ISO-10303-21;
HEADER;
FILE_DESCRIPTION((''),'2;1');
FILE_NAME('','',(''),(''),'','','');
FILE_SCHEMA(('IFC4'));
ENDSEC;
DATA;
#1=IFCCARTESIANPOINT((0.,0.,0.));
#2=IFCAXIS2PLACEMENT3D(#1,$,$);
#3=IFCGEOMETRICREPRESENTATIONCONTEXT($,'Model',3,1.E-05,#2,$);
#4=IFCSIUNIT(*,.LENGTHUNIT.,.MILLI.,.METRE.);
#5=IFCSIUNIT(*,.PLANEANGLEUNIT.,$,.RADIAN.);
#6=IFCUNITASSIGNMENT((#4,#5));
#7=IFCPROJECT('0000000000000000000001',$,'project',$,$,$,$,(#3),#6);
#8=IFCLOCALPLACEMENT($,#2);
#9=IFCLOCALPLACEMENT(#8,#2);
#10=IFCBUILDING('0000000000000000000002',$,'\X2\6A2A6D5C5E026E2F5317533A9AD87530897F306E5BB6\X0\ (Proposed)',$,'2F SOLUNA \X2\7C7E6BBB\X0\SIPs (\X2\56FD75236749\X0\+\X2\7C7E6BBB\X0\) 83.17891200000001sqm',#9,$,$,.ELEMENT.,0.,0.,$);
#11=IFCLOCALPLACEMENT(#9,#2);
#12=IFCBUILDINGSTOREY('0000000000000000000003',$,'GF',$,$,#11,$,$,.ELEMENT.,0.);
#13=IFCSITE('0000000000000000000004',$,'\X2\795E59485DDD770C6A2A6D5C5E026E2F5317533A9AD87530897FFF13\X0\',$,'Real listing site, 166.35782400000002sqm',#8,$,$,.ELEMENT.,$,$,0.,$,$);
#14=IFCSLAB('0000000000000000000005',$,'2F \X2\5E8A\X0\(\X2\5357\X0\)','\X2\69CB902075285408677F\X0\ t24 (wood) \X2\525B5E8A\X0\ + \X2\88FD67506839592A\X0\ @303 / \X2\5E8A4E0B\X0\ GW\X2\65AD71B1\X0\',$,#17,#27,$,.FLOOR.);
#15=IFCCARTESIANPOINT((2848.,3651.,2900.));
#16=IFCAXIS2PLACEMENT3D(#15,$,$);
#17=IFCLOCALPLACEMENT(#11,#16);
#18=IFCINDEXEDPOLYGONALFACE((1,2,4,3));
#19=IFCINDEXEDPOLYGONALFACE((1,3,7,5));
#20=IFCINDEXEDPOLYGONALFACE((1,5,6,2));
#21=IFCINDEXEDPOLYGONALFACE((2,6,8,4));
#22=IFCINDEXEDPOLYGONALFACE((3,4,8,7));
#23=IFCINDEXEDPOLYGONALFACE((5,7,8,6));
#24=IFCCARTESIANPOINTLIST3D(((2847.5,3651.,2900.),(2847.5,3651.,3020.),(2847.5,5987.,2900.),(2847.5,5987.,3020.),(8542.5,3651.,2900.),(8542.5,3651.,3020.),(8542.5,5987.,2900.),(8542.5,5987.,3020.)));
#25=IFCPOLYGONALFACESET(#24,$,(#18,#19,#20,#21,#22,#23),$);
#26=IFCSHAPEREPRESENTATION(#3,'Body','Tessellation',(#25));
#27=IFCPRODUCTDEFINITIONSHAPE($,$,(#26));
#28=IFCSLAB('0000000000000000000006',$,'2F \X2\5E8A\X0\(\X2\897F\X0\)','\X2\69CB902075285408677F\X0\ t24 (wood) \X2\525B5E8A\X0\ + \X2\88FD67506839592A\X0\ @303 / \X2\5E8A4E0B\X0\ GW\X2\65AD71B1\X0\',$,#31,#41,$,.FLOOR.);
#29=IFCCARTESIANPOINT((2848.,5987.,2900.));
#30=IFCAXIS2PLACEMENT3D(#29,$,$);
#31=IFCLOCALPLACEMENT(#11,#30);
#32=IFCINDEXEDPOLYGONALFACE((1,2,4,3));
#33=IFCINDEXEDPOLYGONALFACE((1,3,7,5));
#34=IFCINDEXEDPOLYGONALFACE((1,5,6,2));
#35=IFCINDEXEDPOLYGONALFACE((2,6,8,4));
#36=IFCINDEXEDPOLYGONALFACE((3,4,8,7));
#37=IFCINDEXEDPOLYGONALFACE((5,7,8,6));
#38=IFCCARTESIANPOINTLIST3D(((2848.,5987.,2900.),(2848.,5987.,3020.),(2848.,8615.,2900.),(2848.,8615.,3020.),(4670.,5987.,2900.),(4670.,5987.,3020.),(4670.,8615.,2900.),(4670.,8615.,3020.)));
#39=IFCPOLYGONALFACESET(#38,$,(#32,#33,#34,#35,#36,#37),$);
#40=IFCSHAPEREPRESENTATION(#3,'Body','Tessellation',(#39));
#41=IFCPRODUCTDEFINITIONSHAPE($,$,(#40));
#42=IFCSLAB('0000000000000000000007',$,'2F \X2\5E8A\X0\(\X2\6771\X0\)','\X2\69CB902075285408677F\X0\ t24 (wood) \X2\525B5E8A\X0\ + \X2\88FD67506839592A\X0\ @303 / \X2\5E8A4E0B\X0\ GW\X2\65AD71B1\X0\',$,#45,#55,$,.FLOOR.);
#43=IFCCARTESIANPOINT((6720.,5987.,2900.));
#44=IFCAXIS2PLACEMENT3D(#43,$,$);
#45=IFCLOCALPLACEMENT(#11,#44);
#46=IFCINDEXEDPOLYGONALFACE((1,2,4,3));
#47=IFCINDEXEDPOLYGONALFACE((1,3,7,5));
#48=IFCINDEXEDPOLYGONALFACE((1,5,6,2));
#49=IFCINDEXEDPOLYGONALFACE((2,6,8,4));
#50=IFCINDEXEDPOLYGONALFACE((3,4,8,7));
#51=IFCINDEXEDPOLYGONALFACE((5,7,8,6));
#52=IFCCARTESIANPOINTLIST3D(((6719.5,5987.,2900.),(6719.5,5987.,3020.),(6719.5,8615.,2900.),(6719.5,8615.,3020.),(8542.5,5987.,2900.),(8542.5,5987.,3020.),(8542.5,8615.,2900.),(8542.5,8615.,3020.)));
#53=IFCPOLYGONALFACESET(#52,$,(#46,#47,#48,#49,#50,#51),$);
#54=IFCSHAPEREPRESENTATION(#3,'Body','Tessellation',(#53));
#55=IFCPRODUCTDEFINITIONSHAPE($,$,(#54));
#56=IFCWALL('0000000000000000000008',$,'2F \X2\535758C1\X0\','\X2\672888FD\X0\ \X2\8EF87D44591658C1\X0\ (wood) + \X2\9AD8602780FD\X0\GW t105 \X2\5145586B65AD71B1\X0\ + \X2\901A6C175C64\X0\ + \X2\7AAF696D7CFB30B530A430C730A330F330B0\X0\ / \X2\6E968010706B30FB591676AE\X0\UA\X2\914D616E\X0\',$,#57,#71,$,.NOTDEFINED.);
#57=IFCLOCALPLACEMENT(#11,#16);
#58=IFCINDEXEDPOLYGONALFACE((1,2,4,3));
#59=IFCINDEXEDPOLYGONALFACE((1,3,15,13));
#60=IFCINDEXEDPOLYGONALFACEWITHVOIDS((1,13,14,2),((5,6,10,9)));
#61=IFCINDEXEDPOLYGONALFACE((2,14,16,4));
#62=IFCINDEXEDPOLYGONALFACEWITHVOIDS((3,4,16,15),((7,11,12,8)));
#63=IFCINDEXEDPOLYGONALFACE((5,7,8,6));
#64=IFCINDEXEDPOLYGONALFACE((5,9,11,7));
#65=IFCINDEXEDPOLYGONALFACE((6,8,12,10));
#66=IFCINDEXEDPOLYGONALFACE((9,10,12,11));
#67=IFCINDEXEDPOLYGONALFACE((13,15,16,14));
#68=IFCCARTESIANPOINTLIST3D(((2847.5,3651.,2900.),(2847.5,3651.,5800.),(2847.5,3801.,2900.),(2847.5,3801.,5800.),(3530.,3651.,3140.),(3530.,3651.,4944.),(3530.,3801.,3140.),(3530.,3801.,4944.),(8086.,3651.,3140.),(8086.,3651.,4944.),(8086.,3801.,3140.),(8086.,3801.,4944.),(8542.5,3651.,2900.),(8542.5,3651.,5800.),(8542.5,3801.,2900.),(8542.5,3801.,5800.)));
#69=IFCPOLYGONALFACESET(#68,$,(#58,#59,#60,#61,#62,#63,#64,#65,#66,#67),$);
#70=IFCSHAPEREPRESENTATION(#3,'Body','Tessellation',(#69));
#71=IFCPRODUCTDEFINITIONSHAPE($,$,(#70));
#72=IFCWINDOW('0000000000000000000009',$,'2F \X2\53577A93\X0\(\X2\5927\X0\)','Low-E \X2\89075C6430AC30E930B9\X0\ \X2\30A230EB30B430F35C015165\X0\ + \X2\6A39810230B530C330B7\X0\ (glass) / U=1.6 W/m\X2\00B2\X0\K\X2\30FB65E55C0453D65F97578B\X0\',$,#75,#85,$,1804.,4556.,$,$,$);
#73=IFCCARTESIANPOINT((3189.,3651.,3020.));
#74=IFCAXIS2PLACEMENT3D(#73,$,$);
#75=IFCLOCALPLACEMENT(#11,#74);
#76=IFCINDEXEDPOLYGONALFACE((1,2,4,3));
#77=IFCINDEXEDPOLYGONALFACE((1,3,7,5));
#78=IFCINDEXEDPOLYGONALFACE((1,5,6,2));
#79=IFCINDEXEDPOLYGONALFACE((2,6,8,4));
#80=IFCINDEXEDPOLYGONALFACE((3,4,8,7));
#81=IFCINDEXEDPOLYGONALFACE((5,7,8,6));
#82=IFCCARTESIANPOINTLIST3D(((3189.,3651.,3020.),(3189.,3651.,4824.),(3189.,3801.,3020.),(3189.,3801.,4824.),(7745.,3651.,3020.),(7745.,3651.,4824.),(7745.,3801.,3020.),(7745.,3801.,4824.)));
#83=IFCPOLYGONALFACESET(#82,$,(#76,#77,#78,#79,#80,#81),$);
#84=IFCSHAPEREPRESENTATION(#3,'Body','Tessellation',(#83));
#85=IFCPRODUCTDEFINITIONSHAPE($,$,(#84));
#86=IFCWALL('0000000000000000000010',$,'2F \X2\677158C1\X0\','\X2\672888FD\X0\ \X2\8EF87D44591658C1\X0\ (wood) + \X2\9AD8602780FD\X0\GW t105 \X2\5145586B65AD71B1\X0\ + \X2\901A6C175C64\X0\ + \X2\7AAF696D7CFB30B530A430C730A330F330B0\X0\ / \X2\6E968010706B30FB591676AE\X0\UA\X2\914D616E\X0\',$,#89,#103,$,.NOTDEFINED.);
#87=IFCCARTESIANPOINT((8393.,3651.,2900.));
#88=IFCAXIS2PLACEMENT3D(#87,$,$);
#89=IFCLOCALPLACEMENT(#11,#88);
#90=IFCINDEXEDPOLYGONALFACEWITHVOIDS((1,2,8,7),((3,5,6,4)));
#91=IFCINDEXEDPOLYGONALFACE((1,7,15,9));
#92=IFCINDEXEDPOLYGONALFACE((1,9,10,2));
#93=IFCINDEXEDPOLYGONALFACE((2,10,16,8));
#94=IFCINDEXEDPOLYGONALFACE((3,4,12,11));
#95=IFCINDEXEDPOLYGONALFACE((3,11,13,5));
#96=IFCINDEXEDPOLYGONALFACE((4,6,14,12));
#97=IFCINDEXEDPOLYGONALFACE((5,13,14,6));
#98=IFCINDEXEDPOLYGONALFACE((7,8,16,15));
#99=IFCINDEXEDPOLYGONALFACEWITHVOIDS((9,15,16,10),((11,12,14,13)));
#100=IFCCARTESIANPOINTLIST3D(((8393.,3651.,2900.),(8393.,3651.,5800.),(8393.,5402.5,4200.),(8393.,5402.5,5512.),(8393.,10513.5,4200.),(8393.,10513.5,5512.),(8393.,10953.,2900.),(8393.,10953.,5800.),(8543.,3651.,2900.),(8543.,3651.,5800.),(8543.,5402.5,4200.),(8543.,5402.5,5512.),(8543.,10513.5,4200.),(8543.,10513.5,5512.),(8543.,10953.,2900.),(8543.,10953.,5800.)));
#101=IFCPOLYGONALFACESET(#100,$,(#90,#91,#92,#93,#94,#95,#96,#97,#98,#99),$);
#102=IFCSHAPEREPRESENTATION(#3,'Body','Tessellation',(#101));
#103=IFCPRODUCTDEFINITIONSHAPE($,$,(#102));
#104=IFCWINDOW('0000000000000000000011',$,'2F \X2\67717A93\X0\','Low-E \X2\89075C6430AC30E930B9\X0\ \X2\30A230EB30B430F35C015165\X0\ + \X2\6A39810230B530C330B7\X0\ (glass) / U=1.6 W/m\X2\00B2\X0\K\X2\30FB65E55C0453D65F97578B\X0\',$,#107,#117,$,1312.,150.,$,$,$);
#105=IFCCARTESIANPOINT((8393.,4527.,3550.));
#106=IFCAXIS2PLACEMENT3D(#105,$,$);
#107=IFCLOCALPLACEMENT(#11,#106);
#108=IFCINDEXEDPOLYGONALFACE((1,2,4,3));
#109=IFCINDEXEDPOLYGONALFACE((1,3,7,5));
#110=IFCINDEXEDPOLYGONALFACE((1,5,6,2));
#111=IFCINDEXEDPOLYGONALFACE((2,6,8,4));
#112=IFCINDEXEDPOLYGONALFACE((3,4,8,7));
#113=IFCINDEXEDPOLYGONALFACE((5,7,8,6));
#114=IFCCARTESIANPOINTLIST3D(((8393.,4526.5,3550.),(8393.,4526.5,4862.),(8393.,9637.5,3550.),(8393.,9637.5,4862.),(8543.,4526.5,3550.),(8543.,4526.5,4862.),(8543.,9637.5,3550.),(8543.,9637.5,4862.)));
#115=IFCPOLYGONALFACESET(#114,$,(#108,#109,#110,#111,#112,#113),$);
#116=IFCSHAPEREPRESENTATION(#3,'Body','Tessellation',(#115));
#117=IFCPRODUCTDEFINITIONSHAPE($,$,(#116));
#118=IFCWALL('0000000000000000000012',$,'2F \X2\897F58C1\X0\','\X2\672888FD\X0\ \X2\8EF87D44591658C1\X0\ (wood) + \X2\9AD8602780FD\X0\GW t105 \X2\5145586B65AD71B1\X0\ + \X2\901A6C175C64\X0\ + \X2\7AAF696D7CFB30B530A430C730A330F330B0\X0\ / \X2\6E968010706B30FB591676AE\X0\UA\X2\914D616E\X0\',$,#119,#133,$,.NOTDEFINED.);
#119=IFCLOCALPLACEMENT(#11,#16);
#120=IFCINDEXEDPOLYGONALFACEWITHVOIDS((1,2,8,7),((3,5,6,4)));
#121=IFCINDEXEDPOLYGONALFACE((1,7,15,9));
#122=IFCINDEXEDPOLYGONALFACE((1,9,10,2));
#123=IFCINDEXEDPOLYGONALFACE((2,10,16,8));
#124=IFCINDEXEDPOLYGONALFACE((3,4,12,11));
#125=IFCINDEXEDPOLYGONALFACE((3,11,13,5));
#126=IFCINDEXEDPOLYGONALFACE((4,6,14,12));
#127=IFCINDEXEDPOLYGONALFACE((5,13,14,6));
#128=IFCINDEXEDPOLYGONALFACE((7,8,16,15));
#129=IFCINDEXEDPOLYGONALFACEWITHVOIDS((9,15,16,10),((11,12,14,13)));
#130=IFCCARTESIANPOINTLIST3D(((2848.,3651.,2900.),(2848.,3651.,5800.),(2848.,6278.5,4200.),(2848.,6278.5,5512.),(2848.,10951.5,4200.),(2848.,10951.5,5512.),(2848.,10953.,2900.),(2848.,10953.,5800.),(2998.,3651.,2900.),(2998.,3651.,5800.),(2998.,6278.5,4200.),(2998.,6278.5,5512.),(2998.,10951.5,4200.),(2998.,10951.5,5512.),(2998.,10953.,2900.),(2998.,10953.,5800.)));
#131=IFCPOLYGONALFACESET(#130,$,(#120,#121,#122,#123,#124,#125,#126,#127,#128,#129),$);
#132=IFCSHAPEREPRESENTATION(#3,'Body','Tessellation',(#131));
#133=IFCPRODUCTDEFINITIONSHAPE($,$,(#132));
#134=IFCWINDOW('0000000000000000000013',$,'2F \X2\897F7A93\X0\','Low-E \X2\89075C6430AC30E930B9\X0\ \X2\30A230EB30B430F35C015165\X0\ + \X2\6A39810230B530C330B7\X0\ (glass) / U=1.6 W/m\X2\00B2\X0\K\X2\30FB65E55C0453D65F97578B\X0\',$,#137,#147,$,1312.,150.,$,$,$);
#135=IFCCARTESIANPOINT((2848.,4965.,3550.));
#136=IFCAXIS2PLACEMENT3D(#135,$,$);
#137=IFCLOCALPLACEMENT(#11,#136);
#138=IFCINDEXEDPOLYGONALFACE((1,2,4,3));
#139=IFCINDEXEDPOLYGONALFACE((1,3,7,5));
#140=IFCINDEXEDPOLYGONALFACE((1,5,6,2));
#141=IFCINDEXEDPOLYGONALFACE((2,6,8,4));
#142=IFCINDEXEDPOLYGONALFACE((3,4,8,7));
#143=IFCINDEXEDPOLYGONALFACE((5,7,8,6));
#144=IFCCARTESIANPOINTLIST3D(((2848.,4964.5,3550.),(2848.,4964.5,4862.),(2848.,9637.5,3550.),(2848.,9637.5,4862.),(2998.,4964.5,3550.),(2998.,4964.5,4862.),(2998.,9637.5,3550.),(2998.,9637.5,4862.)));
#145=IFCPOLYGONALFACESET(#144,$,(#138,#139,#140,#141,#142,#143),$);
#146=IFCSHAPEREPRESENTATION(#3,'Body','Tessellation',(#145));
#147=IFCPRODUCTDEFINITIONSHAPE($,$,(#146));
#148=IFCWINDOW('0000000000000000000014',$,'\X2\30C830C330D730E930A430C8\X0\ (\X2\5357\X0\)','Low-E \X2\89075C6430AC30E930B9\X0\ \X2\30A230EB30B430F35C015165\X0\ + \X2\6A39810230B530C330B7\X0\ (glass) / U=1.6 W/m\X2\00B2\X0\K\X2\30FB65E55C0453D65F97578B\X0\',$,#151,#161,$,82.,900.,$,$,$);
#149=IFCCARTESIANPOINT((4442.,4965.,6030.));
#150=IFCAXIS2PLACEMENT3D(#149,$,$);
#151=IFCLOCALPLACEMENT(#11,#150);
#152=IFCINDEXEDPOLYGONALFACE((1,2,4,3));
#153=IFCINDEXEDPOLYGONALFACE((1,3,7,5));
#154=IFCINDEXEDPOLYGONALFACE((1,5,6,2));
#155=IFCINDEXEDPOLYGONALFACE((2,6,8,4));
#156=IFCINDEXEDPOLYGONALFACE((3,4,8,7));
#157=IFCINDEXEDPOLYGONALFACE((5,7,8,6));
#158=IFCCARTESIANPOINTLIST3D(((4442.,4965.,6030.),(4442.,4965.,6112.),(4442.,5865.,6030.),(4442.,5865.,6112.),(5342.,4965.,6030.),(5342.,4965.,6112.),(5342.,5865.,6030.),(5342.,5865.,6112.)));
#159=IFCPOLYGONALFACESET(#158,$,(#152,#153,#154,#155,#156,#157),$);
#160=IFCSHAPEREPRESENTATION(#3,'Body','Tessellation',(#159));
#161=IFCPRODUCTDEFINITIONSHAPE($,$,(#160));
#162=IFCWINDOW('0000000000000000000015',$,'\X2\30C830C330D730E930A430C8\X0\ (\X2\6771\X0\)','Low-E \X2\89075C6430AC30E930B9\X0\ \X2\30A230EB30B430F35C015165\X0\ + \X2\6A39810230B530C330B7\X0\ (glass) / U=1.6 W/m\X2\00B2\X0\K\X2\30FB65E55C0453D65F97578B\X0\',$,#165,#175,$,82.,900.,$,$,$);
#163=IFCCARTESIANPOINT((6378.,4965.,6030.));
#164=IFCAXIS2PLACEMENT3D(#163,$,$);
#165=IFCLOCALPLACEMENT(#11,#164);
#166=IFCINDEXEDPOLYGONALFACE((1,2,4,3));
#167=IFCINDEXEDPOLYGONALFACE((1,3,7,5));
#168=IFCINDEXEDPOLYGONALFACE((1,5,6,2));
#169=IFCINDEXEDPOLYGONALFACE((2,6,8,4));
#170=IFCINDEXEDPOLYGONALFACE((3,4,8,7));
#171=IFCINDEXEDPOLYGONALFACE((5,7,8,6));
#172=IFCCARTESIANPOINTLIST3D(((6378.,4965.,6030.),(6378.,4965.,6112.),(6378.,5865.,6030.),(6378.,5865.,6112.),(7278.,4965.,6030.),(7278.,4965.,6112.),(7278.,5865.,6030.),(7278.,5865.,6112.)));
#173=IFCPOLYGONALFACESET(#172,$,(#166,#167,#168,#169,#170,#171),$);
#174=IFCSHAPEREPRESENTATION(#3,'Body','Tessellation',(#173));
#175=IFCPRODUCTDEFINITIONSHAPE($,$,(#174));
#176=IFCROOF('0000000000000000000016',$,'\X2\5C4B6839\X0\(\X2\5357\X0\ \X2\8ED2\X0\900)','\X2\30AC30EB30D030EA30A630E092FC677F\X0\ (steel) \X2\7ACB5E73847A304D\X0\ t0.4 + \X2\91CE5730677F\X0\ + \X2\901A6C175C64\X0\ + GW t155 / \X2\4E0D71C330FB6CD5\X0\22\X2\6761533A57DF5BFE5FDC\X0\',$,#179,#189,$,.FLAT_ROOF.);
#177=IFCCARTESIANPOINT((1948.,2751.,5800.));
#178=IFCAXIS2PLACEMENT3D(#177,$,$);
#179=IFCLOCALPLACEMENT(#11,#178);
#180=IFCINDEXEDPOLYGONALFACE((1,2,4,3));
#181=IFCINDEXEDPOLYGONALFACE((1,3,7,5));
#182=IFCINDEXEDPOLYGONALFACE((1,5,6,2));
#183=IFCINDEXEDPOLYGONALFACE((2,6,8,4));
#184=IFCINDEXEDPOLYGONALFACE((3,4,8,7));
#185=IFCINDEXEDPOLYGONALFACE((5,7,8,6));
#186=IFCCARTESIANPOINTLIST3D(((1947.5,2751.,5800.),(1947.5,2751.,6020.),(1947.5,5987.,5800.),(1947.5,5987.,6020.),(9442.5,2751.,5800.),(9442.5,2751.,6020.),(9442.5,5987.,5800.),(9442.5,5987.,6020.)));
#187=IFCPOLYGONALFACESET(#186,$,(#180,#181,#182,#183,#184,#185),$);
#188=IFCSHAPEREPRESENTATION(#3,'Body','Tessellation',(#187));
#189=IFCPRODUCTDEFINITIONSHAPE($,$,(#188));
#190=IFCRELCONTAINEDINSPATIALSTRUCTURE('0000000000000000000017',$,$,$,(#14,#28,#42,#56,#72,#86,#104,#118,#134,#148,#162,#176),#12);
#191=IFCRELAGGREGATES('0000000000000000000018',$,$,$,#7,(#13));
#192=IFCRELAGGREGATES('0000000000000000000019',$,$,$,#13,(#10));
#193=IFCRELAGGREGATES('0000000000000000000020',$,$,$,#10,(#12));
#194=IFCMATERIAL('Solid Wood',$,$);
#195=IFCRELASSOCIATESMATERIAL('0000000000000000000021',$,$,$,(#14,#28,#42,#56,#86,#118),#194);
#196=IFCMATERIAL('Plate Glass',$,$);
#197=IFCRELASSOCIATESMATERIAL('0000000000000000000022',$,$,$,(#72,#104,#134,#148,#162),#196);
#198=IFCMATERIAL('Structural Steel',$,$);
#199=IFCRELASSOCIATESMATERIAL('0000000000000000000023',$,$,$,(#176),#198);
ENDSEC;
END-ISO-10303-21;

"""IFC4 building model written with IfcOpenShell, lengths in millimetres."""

from ifc_helpers import new_model, si_unit, frame, frame_2d, origin, place, context, project, spatial, rectangle, extrude, material, element, fill, save


model = new_model("IFC4")

# Units and contexts
model_context = context("Model", 3, precision=1e-05, world=origin())
ifc_project = project(units=[si_unit("LENGTHUNIT", "METRE", prefix="MILLI"), si_unit("PLANEANGLEUNIT", "RADIAN")], contexts=[model_context])

# Site, building, storey
site_placement = place(None, origin())
site = spatial("IfcSite", under=ifc_project, at=site_placement, Name="神奈川県横浜市港北区高田西３", ObjectType="Real listing site, 166.35782400000002sqm", CompositionType="ELEMENT", RefElevation=0.0)
building_placement = place(site_placement, origin())
building = spatial("IfcBuilding", under=site, at=building_placement, Name="横浜市港北区高田西の家 (Proposed)", ObjectType="2F SOLUNA 籾殻SIPs (国産杉+籾殻) 83.17891200000001sqm", CompositionType="ELEMENT", ElevationOfRefHeight=0.0, ElevationOfTerrain=0.0)
storey_placement = place(building_placement, origin())
storey = spatial("IfcBuildingStorey", under=building, at=storey_placement, Name="GF", CompositionType="ELEMENT", Elevation=0.0)

# Slabs
ifc_material_1 = material(Name="Solid Wood")
slab_1_placement = place(storey_placement, frame((2848.0, 3651.0, 2900.0)))
element("IfcSlab", 1, at=slab_1_placement, inside=storey, material=ifc_material_1, Name="2F 床(南)", Description="構造用合板 t24 (wood) 剛床 + 製材根太 @303 / 床下 GW断熱", PredefinedType="FLOOR", context=model_context, shape_type="SweptSolid", body=[
    extrude(rectangle(XDim=5695.0, YDim=2336.0, at=frame_2d((2847.0, 1168.0))), frame((2848.0, 3651.0, 2900.0)), (0.0, 0.0, 1.0), 120.0),
])
slab_2_placement = place(storey_placement, frame((2848.0, 5987.0, 2900.0)))
element("IfcSlab", 2, at=slab_2_placement, inside=storey, material=ifc_material_1, Name="2F 床(西)", Description="構造用合板 t24 (wood) 剛床 + 製材根太 @303 / 床下 GW断熱", PredefinedType="FLOOR", context=model_context, shape_type="SweptSolid", body=[
    extrude(rectangle(XDim=1822.0, YDim=2628.0, at=frame_2d((911.0, 1314.0))), frame((2848.0, 5987.0, 2900.0)), (0.0, 0.0, 1.0), 120.0),
])
slab_3_placement = place(storey_placement, frame((6720.0, 5987.0, 2900.0)))
element("IfcSlab", 3, at=slab_3_placement, inside=storey, material=ifc_material_1, Name="2F 床(東)", Description="構造用合板 t24 (wood) 剛床 + 製材根太 @303 / 床下 GW断熱", PredefinedType="FLOOR", context=model_context, shape_type="SweptSolid", body=[
    extrude(rectangle(XDim=1823.0, YDim=2628.0, at=frame_2d((911.0, 1314.0))), frame((6720.0, 5987.0, 2900.0)), (0.0, 0.0, 1.0), 120.0),
])

# Walls, openings, windows
wall_1_placement = place(storey_placement, frame((2848.0, 3651.0, 2900.0)))
wall_1 = element("IfcWall", 4, at=wall_1_placement, inside=storey, material=ifc_material_1, Name="2F 南壁", Description="木製 軸組外壁 (wood) + 高性能GW t105 充填断熱 + 通気層 + 窯業系サイディング / 準耐火・外皮UA配慮", PredefinedType="NOTDEFINED", context=model_context, shape_type="SweptSolid", body=[
    extrude(rectangle(XDim=5695.0, YDim=150.0, at=frame_2d((2847.0, 75.0))), frame((2848.0, 3651.0, 2900.0)), (0.0, 0.0, 1.0), 2900.0),
])
opening_1_placement = place(storey_placement, frame((3189.0, 3651.0, 3020.0)))
opening_1 = element("IfcOpeningElement", 5, at=opening_1_placement, cuts=wall_1, PredefinedType="NOTDEFINED", context=model_context, shape_type="SweptSolid", body=[
    extrude(rectangle(XDim=4556.0, YDim=150.0, at=frame_2d((2278.0, 75.0))), frame((3189.0, 3651.0, 3020.0)), (0.0, 0.0, 1.0), 1804.0),
])
ifc_material_2 = material(Name="Plate Glass")
window_1_placement = place(storey_placement, frame((3189.0, 3651.0, 3020.0)))
window_1 = element("IfcWindow", 6, at=window_1_placement, inside=storey, material=ifc_material_2, Name="2F 南窓(大)", Description="Low-E 複層ガラス アルゴン封入 + 樹脂サッシ (glass) / U=1.6 W/m²K・日射取得型", OverallHeight=1804.0, OverallWidth=4556.0, context=model_context, shape_type="SweptSolid", body=[
    extrude(rectangle(XDim=4556.0, YDim=150.0, at=frame_2d((2278.0, 75.0))), frame((3189.0, 3651.0, 3020.0)), (0.0, 0.0, 1.0), 1804.0),
])
fill(opening_1, window_1)
wall_2_placement = place(storey_placement, frame((8393.0, 3651.0, 2900.0)))
wall_2 = element("IfcWall", 7, at=wall_2_placement, inside=storey, material=ifc_material_1, Name="2F 東壁", Description="木製 軸組外壁 (wood) + 高性能GW t105 充填断熱 + 通気層 + 窯業系サイディング / 準耐火・外皮UA配慮", PredefinedType="NOTDEFINED", context=model_context, shape_type="SweptSolid", body=[
    extrude(rectangle(XDim=150.0, YDim=7302.0, at=frame_2d((75.0, 3651.0))), frame((8393.0, 3651.0, 2900.0)), (0.0, 0.0, 1.0), 2900.0),
])
opening_2_placement = place(storey_placement, frame((8393.0, 4527.0, 3550.0)))
opening_2 = element("IfcOpeningElement", 8, at=opening_2_placement, cuts=wall_2, PredefinedType="NOTDEFINED", context=model_context, shape_type="SweptSolid", body=[
    extrude(rectangle(XDim=150.0, YDim=5111.0, at=frame_2d((75.0, 2555.0))), frame((8393.0, 4527.0, 3550.0)), (0.0, 0.0, 1.0), 1312.0),
])
window_2_placement = place(storey_placement, frame((8393.0, 4527.0, 3550.0)))
window_2 = element("IfcWindow", 9, at=window_2_placement, inside=storey, material=ifc_material_2, Name="2F 東窓", Description="Low-E 複層ガラス アルゴン封入 + 樹脂サッシ (glass) / U=1.6 W/m²K・日射取得型", OverallHeight=1312.0, OverallWidth=150.0, context=model_context, shape_type="SweptSolid", body=[
    extrude(rectangle(XDim=150.0, YDim=5111.0, at=frame_2d((75.0, 2555.0))), frame((8393.0, 4527.0, 3550.0)), (0.0, 0.0, 1.0), 1312.0),
])
fill(opening_2, window_2)
wall_3_placement = place(storey_placement, frame((2848.0, 3651.0, 2900.0)))
wall_3 = element("IfcWall", 10, at=wall_3_placement, inside=storey, material=ifc_material_1, Name="2F 西壁", Description="木製 軸組外壁 (wood) + 高性能GW t105 充填断熱 + 通気層 + 窯業系サイディング / 準耐火・外皮UA配慮", PredefinedType="NOTDEFINED", context=model_context, shape_type="SweptSolid", body=[
    extrude(rectangle(XDim=150.0, YDim=7302.0, at=frame_2d((75.0, 3651.0))), frame((2848.0, 3651.0, 2900.0)), (0.0, 0.0, 1.0), 2900.0),
])
opening_3_placement = place(storey_placement, frame((2848.0, 4965.0, 3550.0)))
opening_3 = element("IfcOpeningElement", 11, at=opening_3_placement, cuts=wall_3, PredefinedType="NOTDEFINED", context=model_context, shape_type="SweptSolid", body=[
    extrude(rectangle(XDim=150.0, YDim=4673.0, at=frame_2d((75.0, 2336.0))), frame((2848.0, 4965.0, 3550.0)), (0.0, 0.0, 1.0), 1312.0),
])
window_3_placement = place(storey_placement, frame((2848.0, 4965.0, 3550.0)))
window_3 = element("IfcWindow", 12, at=window_3_placement, inside=storey, material=ifc_material_2, Name="2F 西窓", Description="Low-E 複層ガラス アルゴン封入 + 樹脂サッシ (glass) / U=1.6 W/m²K・日射取得型", OverallHeight=1312.0, OverallWidth=150.0, context=model_context, shape_type="SweptSolid", body=[
    extrude(rectangle(XDim=150.0, YDim=4673.0, at=frame_2d((75.0, 2336.0))), frame((2848.0, 4965.0, 3550.0)), (0.0, 0.0, 1.0), 1312.0),
])
fill(opening_3, window_3)

# Windows
window_4_placement = place(storey_placement, frame((4442.0, 4965.0, 6030.0)))
element("IfcWindow", 13, at=window_4_placement, inside=storey, material=ifc_material_2, Name="トップライト (南)", Description="Low-E 複層ガラス アルゴン封入 + 樹脂サッシ (glass) / U=1.6 W/m²K・日射取得型", OverallHeight=82.0, OverallWidth=900.0, context=model_context, shape_type="SweptSolid", body=[
    extrude(rectangle(XDim=900.0, YDim=900.0, at=frame_2d((450.0, 450.0))), frame((4442.0, 4965.0, 6030.0)), (0.0, 0.0, 1.0), 82.0),
])
window_5_placement = place(storey_placement, frame((6378.0, 4965.0, 6030.0)))
element("IfcWindow", 14, at=window_5_placement, inside=storey, material=ifc_material_2, Name="トップライト (東)", Description="Low-E 複層ガラス アルゴン封入 + 樹脂サッシ (glass) / U=1.6 W/m²K・日射取得型", OverallHeight=82.0, OverallWidth=900.0, context=model_context, shape_type="SweptSolid", body=[
    extrude(rectangle(XDim=900.0, YDim=900.0, at=frame_2d((450.0, 450.0))), frame((6378.0, 4965.0, 6030.0)), (0.0, 0.0, 1.0), 82.0),
])

# Roof
ifc_material_3 = material(Name="Structural Steel")
roof_1_placement = place(storey_placement, frame((1948.0, 2751.0, 5800.0)))
element("IfcRoof", 15, at=roof_1_placement, inside=storey, material=ifc_material_3, Name="屋根(南 軒900)", Description="ガルバリウム鋼板 (steel) 立平葺き t0.4 + 野地板 + 通気層 + GW t155 / 不燃・法22条区域対応", PredefinedType="FLAT_ROOF", context=model_context, shape_type="SweptSolid", body=[
    extrude(rectangle(XDim=7495.0, YDim=3236.0, at=frame_2d((3747.0, 1618.0))), frame((1948.0, 2751.0, 5800.0)), (0.0, 0.0, 1.0), 220.0),
])

save(model, "model.ifc")
